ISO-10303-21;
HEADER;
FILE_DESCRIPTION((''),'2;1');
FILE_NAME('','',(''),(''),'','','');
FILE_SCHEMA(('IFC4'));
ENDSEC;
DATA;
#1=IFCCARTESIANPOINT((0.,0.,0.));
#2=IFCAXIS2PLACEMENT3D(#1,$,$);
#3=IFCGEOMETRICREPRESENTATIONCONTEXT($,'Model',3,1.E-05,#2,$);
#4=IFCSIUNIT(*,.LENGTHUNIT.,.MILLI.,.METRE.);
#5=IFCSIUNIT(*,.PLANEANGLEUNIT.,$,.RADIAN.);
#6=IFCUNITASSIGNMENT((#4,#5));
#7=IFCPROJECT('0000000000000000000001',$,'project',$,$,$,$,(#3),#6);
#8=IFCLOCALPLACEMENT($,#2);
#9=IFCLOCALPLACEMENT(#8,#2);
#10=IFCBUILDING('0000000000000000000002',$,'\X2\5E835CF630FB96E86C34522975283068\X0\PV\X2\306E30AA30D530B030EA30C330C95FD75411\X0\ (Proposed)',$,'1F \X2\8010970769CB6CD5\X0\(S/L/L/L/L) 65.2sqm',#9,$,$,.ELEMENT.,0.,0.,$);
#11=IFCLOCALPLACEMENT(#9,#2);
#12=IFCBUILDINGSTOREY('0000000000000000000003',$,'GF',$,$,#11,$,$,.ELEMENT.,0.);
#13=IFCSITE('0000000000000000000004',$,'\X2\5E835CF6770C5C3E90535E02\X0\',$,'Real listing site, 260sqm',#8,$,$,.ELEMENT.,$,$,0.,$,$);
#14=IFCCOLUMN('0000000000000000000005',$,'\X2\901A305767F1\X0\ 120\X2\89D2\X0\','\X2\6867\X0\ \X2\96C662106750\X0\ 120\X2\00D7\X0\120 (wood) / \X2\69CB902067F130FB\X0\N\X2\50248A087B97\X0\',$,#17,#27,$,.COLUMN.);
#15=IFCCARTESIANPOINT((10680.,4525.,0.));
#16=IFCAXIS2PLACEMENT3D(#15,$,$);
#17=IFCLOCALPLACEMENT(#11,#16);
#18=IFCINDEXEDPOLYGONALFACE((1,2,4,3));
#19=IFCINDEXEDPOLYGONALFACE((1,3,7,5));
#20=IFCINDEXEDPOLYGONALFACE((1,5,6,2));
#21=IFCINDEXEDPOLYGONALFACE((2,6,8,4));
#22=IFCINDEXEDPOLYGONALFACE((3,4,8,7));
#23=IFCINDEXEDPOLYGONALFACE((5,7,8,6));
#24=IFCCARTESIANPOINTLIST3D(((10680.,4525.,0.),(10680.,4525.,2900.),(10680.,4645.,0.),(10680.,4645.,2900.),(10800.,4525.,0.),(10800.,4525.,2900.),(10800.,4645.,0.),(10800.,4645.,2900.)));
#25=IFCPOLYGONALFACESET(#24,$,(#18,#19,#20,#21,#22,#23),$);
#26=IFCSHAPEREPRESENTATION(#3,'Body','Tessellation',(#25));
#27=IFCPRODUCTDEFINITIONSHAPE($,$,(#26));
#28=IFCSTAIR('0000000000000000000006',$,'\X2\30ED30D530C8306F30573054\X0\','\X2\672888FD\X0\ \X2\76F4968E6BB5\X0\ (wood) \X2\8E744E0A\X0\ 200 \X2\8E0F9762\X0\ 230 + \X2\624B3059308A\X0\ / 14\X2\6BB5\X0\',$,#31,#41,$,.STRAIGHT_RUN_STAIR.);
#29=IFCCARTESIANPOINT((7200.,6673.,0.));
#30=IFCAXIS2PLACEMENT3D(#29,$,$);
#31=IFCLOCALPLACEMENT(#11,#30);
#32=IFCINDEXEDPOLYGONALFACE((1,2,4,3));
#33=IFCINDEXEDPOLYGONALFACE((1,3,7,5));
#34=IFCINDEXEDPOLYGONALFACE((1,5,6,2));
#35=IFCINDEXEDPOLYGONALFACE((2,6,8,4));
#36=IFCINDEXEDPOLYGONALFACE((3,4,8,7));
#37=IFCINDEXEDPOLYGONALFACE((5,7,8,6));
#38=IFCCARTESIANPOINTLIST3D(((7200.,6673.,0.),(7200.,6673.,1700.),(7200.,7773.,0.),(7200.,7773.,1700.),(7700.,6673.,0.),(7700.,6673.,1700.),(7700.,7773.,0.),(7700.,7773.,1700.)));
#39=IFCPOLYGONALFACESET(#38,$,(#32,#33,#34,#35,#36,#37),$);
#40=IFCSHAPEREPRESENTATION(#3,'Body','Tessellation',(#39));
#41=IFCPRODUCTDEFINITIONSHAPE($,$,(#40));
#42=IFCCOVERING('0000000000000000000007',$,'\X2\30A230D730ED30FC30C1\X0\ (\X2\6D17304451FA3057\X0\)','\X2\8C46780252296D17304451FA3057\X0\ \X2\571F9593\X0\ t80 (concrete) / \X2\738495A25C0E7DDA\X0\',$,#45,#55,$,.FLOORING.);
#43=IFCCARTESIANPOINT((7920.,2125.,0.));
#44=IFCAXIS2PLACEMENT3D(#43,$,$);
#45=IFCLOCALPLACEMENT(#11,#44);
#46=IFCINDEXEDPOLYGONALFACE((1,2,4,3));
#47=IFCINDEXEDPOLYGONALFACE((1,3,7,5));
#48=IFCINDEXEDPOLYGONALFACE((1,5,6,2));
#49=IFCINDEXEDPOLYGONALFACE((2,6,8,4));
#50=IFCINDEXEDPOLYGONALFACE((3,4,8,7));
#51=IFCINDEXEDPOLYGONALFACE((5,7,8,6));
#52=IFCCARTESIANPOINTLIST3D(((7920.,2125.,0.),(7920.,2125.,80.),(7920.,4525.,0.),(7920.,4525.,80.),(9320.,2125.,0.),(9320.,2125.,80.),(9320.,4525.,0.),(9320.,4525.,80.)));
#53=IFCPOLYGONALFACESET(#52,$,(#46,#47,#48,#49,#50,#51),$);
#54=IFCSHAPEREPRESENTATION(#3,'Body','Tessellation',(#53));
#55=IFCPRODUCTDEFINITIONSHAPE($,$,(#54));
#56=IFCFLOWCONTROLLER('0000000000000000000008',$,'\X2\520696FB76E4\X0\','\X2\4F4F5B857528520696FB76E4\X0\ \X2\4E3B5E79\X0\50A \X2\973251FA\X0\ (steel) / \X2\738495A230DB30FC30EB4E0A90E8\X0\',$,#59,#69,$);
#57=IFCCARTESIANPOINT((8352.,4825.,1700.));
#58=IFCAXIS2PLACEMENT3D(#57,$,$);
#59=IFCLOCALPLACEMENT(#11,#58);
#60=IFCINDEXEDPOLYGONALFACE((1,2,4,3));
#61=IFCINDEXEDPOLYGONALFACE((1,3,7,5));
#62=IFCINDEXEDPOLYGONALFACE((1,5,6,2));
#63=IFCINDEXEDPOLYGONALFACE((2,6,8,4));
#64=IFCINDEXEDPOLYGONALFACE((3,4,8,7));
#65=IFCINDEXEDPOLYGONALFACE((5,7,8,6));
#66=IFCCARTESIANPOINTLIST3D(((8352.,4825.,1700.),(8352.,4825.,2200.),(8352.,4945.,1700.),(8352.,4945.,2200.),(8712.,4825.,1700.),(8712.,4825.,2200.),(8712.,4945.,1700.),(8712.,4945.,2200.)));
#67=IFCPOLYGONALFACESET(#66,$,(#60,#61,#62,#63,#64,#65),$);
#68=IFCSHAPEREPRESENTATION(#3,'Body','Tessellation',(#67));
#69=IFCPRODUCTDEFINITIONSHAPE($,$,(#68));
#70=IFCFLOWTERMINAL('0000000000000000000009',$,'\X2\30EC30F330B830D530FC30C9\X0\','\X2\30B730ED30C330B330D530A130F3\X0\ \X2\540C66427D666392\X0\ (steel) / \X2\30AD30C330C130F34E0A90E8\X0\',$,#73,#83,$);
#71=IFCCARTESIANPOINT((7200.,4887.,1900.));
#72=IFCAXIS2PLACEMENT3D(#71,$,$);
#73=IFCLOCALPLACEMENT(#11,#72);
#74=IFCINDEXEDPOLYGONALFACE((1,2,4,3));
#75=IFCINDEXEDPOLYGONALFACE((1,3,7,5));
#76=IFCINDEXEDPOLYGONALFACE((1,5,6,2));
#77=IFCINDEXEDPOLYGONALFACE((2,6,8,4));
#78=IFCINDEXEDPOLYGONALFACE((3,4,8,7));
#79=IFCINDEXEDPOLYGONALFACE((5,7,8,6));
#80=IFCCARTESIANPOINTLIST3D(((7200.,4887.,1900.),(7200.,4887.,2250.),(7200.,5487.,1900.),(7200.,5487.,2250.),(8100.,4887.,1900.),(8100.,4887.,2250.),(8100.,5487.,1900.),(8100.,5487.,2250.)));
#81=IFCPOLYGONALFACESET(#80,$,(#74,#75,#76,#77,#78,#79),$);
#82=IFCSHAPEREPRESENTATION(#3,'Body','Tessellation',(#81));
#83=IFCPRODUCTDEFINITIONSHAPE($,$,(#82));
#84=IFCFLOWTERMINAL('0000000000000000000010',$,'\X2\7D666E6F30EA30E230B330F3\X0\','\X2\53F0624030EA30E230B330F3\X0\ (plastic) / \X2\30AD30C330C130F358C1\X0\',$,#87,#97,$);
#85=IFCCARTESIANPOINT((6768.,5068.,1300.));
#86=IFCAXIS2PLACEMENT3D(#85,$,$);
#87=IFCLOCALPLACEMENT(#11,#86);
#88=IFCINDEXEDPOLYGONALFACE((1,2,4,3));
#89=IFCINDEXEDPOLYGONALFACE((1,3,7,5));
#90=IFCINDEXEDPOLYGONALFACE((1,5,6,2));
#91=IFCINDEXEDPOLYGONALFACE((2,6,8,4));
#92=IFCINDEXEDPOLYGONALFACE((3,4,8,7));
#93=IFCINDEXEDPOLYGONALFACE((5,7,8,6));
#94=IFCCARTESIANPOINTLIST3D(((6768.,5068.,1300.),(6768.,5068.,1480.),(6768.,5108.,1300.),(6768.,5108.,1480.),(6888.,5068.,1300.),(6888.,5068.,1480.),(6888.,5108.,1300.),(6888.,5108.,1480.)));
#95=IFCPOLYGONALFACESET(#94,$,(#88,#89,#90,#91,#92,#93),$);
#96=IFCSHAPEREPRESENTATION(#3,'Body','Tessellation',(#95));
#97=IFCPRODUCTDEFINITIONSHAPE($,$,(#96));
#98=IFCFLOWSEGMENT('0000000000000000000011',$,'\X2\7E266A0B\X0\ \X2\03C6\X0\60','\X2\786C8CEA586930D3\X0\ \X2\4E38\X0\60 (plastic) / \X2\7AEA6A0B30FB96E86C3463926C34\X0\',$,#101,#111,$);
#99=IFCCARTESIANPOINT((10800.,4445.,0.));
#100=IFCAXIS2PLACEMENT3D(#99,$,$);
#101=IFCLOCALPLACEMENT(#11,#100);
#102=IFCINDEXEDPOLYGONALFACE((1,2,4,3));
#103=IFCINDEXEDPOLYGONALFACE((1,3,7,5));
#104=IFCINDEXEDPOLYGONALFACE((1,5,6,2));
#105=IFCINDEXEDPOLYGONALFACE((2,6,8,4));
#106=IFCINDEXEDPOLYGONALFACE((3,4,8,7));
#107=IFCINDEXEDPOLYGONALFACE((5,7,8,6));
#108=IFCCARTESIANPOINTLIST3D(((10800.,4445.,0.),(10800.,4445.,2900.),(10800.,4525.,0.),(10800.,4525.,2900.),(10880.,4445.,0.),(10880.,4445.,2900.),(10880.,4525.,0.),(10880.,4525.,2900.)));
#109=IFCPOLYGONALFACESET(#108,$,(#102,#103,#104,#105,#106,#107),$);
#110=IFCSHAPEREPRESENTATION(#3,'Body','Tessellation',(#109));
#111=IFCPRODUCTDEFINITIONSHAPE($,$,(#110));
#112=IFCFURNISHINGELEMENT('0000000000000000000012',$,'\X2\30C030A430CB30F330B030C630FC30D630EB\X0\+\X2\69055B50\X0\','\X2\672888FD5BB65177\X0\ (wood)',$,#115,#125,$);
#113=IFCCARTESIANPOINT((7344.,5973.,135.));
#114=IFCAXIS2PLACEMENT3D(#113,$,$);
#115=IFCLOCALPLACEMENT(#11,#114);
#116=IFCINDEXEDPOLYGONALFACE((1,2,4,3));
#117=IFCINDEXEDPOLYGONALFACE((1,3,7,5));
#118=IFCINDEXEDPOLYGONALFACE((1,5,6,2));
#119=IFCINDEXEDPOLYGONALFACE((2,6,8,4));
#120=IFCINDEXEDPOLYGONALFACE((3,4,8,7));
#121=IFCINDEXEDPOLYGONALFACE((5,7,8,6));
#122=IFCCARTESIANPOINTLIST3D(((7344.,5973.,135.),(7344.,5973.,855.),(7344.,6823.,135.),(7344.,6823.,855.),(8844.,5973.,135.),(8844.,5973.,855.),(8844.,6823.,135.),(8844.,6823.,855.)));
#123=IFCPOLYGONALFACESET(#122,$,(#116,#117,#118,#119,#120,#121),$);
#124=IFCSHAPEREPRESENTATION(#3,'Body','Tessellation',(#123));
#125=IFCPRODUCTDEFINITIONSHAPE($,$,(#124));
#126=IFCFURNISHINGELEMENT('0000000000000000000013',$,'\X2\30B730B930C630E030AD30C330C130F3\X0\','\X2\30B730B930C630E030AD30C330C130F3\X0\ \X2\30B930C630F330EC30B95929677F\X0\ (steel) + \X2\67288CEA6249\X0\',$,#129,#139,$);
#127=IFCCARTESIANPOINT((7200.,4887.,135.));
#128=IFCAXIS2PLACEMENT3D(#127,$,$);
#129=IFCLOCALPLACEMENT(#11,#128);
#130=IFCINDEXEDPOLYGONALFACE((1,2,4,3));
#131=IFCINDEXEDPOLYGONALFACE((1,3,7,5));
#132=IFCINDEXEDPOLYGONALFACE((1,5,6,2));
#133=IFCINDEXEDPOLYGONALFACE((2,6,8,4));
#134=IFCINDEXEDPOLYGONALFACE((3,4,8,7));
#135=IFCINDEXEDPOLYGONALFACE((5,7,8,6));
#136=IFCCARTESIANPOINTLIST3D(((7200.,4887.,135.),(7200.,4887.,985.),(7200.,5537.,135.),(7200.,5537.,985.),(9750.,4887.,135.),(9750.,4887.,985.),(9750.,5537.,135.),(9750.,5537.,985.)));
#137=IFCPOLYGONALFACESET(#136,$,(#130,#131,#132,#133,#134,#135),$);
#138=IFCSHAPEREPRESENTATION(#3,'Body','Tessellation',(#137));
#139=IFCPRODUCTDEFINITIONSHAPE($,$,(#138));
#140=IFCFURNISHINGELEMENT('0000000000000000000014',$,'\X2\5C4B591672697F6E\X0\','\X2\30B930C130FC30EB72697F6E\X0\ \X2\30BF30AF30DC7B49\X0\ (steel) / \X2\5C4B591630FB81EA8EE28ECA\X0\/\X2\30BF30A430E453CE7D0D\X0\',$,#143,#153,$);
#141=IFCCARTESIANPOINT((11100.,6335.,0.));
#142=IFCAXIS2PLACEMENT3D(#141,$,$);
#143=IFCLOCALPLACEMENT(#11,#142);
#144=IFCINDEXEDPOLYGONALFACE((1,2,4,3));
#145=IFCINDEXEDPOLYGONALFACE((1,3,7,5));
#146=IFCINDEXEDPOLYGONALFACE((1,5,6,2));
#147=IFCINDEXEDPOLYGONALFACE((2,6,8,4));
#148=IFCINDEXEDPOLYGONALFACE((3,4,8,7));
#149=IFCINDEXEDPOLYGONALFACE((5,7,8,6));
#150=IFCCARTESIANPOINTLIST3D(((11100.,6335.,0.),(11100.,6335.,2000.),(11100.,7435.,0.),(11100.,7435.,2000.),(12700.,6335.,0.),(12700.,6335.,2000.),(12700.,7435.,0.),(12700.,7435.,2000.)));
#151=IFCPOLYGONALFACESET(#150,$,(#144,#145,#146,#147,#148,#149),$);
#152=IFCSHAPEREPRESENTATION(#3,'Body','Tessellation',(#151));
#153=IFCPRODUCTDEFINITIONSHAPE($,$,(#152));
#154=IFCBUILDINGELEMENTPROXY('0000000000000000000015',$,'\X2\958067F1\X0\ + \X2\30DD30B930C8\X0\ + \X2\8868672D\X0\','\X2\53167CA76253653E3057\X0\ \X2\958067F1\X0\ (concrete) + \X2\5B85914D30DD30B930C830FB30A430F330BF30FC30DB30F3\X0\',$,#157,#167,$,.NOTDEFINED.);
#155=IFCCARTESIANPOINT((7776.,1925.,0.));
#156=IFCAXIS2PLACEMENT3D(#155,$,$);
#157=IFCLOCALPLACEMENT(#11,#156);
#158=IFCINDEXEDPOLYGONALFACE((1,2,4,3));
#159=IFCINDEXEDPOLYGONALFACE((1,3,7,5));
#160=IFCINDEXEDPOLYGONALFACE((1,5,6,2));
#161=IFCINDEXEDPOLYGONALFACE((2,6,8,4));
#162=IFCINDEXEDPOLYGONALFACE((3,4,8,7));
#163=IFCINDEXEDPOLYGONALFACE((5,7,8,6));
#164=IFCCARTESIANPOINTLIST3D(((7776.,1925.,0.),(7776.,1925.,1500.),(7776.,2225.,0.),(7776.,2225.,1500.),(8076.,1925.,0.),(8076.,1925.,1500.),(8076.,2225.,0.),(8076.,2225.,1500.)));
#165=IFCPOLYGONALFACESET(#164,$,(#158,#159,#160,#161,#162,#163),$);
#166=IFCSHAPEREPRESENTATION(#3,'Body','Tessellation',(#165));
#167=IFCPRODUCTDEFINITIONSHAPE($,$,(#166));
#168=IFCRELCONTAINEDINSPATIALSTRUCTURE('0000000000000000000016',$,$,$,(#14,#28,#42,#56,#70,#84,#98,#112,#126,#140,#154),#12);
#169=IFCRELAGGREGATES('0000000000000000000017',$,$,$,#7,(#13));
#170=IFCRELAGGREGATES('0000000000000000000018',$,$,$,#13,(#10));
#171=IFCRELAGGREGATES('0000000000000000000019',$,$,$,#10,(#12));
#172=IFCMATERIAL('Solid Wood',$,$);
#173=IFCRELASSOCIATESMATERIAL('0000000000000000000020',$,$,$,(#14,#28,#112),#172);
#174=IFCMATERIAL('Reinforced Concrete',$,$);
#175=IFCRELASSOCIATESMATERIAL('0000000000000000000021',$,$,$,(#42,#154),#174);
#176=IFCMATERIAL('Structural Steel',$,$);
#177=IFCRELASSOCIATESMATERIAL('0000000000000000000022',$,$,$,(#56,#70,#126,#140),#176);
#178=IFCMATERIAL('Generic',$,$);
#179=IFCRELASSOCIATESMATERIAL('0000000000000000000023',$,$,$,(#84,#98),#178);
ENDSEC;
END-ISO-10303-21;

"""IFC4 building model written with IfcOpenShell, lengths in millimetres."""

from ifc_helpers import new_model, si_unit, frame, frame_2d, origin, place, context, project, spatial, rectangle, extrude, material, element, save


model = new_model("IFC4")

# Units and contexts
model_context = context("Model", 3, precision=1e-05, world=origin())
ifc_project = project(units=[si_unit("LENGTHUNIT", "METRE", prefix="MILLI"), si_unit("PLANEANGLEUNIT", "RADIAN")], contexts=[model_context])

# Site, building, storey
site_placement = place(None, origin())
site = spatial("IfcSite", under=ifc_project, at=site_placement, Name="広島県尾道市", ObjectType="Real listing site, 260sqm", CompositionType="ELEMENT", RefElevation=0.0)
building_placement = place(site_placement, origin())
building = spatial("IfcBuilding", under=site, at=building_placement, Name="広島・雨水利用とPVのオフグリッド志向 (Proposed)", ObjectType="1F 耐震構法(S/L/L/L/L) 65.2sqm", CompositionType="ELEMENT", ElevationOfRefHeight=0.0, ElevationOfTerrain=0.0)
storey_placement = place(building_placement, origin())
storey = spatial("IfcBuildingStorey", under=building, at=storey_placement, Name="GF", CompositionType="ELEMENT", Elevation=0.0)

# Column
ifc_material_1 = material(Name="Solid Wood")
column_1_placement = place(storey_placement, frame((10680.0, 4525.0, 0.0)))
element("IfcColumn", 1, at=column_1_placement, inside=storey, material=ifc_material_1, Name="通し柱 120角", Description="桧 集成材 120×120 (wood) / 構造柱・N値計算", PredefinedType="COLUMN", context=model_context, shape_type="SweptSolid", body=[
    extrude(rectangle(XDim=120.0, YDim=120.0, at=frame_2d((60.0, 60.0))), frame((10680.0, 4525.0, 0.0)), (0.0, 0.0, 1.0), 2900.0),
])

# Stair
stair_placement = place(storey_placement, frame((7200.0, 6673.0, 0.0)))
element("IfcStair", 2, at=stair_placement, inside=storey, material=ifc_material_1, Name="ロフトはしご", Description="木製 直階段 (wood) 蹴上 200 踏面 230 + 手すり / 14段", PredefinedType="STRAIGHT_RUN_STAIR", context=model_context, shape_type="SweptSolid", body=[
    extrude(rectangle(XDim=500.0, YDim=1100.0, at=frame_2d((250.0, 550.0))), frame((7200.0, 6673.0, 0.0)), (0.0, 0.0, 1.0), 1700.0),
])

# Covering
ifc_material_2 = material(Name="Reinforced Concrete")
covering_placement = place(storey_placement, frame((7920.0, 2125.0, 0.0)))
element("IfcCovering", 3, at=covering_placement, inside=storey, material=ifc_material_2, Name="アプローチ (洗い出し)", Description="豆砂利洗い出し 土間 t80 (concrete) / 玄関導線", PredefinedType="FLOORING", context=model_context, shape_type="SweptSolid", body=[
    extrude(rectangle(XDim=1400.0, YDim=2400.0, at=frame_2d((700.0, 1200.0))), frame((7920.0, 2125.0, 0.0)), (0.0, 0.0, 1.0), 80.0),
])

# Flow controller
ifc_material_3 = material(Name="Structural Steel")
flow_controller_placement = place(storey_placement, frame((8352.0, 4825.0, 1700.0)))
element("IfcFlowController", 4, at=flow_controller_placement, inside=storey, material=ifc_material_3, Name="分電盤", Description="住宅用分電盤 主幹50A 露出 (steel) / 玄関ホール上部", context=model_context, shape_type="SweptSolid", body=[
    extrude(rectangle(XDim=360.0, YDim=120.0, at=frame_2d((180.0, 60.0))), frame((8352.0, 4825.0, 1700.0)), (0.0, 0.0, 1.0), 500.0),
])

# Flow terminals
flow_terminal_1_placement = place(storey_placement, frame((7200.0, 4887.0, 1900.0)))
element("IfcFlowTerminal", 5, at=flow_terminal_1_placement, inside=storey, material=ifc_material_3, Name="レンジフード", Description="シロッコファン 同時給排 (steel) / キッチン上部", context=model_context, shape_type="SweptSolid", body=[
    extrude(rectangle(XDim=900.0, YDim=600.0, at=frame_2d((450.0, 300.0))), frame((7200.0, 4887.0, 1900.0)), (0.0, 0.0, 1.0), 350.0),
])
ifc_material_4 = material(Name="Generic")
flow_terminal_2_placement = place(storey_placement, frame((6768.0, 5068.0, 1300.0)))
element("IfcFlowTerminal", 6, at=flow_terminal_2_placement, inside=storey, material=ifc_material_4, Name="給湯リモコン", Description="台所リモコン (plastic) / キッチン壁", context=model_context, shape_type="SweptSolid", body=[
    extrude(rectangle(XDim=120.0, YDim=40.0, at=frame_2d((60.0, 20.0))), frame((6768.0, 5068.0, 1300.0)), (0.0, 0.0, 1.0), 180.0),
])

# Flow segment
flow_segment_placement = place(storey_placement, frame((10800.0, 4445.0, 0.0)))
element("IfcFlowSegment", 7, at=flow_segment_placement, inside=storey, material=ifc_material_4, Name="縦樋 φ60", Description="硬質塩ビ 丸60 (plastic) / 竪樋・雨水排水", context=model_context, shape_type="SweptSolid", body=[
    extrude(rectangle(XDim=80.0, YDim=80.0, at=frame_2d((40.0, 40.0))), frame((10800.0, 4445.0, 0.0)), (0.0, 0.0, 1.0), 2900.0),
])

# Furnishing elements
furnishing_1_placement = place(storey_placement, frame((7344.0, 5973.0, 135.0)))
element("IfcFurnishingElement", 8, at=furnishing_1_placement, inside=storey, material=ifc_material_1, Name="ダイニングテーブル+椅子", Description="木製家具 (wood)", context=model_context, shape_type="SweptSolid", body=[
    extrude(rectangle(XDim=1500.0, YDim=850.0, at=frame_2d((750.0, 425.0))), frame((7344.0, 5973.0, 135.0)), (0.0, 0.0, 1.0), 720.0),
])
furnishing_2_placement = place(storey_placement, frame((7200.0, 4887.0, 135.0)))
element("IfcFurnishingElement", 9, at=furnishing_2_placement, inside=storey, material=ifc_material_3, Name="システムキッチン", Description="システムキッチン ステンレス天板 (steel) + 木質扉", context=model_context, shape_type="SweptSolid", body=[
    extrude(rectangle(XDim=2550.0, YDim=650.0, at=frame_2d((1275.0, 325.0))), frame((7200.0, 4887.0, 135.0)), (0.0, 0.0, 1.0), 850.0),
])
furnishing_3_placement = place(storey_placement, frame((11100.0, 6335.0, 0.0)))
element("IfcFurnishingElement", 10, at=furnishing_3_placement, inside=storey, material=ifc_material_3, Name="屋外物置", Description="スチール物置 タクボ等 (steel) / 屋外・自転車/タイヤ収納", context=model_context, shape_type="SweptSolid", body=[
    extrude(rectangle(XDim=1600.0, YDim=1100.0, at=frame_2d((800.0, 550.0))), frame((11100.0, 6335.0, 0.0)), (0.0, 0.0, 1.0), 2000.0),
])

# Building element proxy
proxy_placement = place(storey_placement, frame((7776.0, 1925.0, 0.0)))
element("IfcBuildingElementProxy", 11, at=proxy_placement, inside=storey, material=ifc_material_2, Name="門柱 + ポスト + 表札", Description="化粧打放し 門柱 (concrete) + 宅配ポスト・インターホン", PredefinedType="NOTDEFINED", context=model_context, shape_type="SweptSolid", body=[
    extrude(rectangle(XDim=300.0, YDim=300.0, at=frame_2d((150.0, 150.0))), frame((7776.0, 1925.0, 0.0)), (0.0, 0.0, 1.0), 1500.0),
])

save(model, "model.ifc")
